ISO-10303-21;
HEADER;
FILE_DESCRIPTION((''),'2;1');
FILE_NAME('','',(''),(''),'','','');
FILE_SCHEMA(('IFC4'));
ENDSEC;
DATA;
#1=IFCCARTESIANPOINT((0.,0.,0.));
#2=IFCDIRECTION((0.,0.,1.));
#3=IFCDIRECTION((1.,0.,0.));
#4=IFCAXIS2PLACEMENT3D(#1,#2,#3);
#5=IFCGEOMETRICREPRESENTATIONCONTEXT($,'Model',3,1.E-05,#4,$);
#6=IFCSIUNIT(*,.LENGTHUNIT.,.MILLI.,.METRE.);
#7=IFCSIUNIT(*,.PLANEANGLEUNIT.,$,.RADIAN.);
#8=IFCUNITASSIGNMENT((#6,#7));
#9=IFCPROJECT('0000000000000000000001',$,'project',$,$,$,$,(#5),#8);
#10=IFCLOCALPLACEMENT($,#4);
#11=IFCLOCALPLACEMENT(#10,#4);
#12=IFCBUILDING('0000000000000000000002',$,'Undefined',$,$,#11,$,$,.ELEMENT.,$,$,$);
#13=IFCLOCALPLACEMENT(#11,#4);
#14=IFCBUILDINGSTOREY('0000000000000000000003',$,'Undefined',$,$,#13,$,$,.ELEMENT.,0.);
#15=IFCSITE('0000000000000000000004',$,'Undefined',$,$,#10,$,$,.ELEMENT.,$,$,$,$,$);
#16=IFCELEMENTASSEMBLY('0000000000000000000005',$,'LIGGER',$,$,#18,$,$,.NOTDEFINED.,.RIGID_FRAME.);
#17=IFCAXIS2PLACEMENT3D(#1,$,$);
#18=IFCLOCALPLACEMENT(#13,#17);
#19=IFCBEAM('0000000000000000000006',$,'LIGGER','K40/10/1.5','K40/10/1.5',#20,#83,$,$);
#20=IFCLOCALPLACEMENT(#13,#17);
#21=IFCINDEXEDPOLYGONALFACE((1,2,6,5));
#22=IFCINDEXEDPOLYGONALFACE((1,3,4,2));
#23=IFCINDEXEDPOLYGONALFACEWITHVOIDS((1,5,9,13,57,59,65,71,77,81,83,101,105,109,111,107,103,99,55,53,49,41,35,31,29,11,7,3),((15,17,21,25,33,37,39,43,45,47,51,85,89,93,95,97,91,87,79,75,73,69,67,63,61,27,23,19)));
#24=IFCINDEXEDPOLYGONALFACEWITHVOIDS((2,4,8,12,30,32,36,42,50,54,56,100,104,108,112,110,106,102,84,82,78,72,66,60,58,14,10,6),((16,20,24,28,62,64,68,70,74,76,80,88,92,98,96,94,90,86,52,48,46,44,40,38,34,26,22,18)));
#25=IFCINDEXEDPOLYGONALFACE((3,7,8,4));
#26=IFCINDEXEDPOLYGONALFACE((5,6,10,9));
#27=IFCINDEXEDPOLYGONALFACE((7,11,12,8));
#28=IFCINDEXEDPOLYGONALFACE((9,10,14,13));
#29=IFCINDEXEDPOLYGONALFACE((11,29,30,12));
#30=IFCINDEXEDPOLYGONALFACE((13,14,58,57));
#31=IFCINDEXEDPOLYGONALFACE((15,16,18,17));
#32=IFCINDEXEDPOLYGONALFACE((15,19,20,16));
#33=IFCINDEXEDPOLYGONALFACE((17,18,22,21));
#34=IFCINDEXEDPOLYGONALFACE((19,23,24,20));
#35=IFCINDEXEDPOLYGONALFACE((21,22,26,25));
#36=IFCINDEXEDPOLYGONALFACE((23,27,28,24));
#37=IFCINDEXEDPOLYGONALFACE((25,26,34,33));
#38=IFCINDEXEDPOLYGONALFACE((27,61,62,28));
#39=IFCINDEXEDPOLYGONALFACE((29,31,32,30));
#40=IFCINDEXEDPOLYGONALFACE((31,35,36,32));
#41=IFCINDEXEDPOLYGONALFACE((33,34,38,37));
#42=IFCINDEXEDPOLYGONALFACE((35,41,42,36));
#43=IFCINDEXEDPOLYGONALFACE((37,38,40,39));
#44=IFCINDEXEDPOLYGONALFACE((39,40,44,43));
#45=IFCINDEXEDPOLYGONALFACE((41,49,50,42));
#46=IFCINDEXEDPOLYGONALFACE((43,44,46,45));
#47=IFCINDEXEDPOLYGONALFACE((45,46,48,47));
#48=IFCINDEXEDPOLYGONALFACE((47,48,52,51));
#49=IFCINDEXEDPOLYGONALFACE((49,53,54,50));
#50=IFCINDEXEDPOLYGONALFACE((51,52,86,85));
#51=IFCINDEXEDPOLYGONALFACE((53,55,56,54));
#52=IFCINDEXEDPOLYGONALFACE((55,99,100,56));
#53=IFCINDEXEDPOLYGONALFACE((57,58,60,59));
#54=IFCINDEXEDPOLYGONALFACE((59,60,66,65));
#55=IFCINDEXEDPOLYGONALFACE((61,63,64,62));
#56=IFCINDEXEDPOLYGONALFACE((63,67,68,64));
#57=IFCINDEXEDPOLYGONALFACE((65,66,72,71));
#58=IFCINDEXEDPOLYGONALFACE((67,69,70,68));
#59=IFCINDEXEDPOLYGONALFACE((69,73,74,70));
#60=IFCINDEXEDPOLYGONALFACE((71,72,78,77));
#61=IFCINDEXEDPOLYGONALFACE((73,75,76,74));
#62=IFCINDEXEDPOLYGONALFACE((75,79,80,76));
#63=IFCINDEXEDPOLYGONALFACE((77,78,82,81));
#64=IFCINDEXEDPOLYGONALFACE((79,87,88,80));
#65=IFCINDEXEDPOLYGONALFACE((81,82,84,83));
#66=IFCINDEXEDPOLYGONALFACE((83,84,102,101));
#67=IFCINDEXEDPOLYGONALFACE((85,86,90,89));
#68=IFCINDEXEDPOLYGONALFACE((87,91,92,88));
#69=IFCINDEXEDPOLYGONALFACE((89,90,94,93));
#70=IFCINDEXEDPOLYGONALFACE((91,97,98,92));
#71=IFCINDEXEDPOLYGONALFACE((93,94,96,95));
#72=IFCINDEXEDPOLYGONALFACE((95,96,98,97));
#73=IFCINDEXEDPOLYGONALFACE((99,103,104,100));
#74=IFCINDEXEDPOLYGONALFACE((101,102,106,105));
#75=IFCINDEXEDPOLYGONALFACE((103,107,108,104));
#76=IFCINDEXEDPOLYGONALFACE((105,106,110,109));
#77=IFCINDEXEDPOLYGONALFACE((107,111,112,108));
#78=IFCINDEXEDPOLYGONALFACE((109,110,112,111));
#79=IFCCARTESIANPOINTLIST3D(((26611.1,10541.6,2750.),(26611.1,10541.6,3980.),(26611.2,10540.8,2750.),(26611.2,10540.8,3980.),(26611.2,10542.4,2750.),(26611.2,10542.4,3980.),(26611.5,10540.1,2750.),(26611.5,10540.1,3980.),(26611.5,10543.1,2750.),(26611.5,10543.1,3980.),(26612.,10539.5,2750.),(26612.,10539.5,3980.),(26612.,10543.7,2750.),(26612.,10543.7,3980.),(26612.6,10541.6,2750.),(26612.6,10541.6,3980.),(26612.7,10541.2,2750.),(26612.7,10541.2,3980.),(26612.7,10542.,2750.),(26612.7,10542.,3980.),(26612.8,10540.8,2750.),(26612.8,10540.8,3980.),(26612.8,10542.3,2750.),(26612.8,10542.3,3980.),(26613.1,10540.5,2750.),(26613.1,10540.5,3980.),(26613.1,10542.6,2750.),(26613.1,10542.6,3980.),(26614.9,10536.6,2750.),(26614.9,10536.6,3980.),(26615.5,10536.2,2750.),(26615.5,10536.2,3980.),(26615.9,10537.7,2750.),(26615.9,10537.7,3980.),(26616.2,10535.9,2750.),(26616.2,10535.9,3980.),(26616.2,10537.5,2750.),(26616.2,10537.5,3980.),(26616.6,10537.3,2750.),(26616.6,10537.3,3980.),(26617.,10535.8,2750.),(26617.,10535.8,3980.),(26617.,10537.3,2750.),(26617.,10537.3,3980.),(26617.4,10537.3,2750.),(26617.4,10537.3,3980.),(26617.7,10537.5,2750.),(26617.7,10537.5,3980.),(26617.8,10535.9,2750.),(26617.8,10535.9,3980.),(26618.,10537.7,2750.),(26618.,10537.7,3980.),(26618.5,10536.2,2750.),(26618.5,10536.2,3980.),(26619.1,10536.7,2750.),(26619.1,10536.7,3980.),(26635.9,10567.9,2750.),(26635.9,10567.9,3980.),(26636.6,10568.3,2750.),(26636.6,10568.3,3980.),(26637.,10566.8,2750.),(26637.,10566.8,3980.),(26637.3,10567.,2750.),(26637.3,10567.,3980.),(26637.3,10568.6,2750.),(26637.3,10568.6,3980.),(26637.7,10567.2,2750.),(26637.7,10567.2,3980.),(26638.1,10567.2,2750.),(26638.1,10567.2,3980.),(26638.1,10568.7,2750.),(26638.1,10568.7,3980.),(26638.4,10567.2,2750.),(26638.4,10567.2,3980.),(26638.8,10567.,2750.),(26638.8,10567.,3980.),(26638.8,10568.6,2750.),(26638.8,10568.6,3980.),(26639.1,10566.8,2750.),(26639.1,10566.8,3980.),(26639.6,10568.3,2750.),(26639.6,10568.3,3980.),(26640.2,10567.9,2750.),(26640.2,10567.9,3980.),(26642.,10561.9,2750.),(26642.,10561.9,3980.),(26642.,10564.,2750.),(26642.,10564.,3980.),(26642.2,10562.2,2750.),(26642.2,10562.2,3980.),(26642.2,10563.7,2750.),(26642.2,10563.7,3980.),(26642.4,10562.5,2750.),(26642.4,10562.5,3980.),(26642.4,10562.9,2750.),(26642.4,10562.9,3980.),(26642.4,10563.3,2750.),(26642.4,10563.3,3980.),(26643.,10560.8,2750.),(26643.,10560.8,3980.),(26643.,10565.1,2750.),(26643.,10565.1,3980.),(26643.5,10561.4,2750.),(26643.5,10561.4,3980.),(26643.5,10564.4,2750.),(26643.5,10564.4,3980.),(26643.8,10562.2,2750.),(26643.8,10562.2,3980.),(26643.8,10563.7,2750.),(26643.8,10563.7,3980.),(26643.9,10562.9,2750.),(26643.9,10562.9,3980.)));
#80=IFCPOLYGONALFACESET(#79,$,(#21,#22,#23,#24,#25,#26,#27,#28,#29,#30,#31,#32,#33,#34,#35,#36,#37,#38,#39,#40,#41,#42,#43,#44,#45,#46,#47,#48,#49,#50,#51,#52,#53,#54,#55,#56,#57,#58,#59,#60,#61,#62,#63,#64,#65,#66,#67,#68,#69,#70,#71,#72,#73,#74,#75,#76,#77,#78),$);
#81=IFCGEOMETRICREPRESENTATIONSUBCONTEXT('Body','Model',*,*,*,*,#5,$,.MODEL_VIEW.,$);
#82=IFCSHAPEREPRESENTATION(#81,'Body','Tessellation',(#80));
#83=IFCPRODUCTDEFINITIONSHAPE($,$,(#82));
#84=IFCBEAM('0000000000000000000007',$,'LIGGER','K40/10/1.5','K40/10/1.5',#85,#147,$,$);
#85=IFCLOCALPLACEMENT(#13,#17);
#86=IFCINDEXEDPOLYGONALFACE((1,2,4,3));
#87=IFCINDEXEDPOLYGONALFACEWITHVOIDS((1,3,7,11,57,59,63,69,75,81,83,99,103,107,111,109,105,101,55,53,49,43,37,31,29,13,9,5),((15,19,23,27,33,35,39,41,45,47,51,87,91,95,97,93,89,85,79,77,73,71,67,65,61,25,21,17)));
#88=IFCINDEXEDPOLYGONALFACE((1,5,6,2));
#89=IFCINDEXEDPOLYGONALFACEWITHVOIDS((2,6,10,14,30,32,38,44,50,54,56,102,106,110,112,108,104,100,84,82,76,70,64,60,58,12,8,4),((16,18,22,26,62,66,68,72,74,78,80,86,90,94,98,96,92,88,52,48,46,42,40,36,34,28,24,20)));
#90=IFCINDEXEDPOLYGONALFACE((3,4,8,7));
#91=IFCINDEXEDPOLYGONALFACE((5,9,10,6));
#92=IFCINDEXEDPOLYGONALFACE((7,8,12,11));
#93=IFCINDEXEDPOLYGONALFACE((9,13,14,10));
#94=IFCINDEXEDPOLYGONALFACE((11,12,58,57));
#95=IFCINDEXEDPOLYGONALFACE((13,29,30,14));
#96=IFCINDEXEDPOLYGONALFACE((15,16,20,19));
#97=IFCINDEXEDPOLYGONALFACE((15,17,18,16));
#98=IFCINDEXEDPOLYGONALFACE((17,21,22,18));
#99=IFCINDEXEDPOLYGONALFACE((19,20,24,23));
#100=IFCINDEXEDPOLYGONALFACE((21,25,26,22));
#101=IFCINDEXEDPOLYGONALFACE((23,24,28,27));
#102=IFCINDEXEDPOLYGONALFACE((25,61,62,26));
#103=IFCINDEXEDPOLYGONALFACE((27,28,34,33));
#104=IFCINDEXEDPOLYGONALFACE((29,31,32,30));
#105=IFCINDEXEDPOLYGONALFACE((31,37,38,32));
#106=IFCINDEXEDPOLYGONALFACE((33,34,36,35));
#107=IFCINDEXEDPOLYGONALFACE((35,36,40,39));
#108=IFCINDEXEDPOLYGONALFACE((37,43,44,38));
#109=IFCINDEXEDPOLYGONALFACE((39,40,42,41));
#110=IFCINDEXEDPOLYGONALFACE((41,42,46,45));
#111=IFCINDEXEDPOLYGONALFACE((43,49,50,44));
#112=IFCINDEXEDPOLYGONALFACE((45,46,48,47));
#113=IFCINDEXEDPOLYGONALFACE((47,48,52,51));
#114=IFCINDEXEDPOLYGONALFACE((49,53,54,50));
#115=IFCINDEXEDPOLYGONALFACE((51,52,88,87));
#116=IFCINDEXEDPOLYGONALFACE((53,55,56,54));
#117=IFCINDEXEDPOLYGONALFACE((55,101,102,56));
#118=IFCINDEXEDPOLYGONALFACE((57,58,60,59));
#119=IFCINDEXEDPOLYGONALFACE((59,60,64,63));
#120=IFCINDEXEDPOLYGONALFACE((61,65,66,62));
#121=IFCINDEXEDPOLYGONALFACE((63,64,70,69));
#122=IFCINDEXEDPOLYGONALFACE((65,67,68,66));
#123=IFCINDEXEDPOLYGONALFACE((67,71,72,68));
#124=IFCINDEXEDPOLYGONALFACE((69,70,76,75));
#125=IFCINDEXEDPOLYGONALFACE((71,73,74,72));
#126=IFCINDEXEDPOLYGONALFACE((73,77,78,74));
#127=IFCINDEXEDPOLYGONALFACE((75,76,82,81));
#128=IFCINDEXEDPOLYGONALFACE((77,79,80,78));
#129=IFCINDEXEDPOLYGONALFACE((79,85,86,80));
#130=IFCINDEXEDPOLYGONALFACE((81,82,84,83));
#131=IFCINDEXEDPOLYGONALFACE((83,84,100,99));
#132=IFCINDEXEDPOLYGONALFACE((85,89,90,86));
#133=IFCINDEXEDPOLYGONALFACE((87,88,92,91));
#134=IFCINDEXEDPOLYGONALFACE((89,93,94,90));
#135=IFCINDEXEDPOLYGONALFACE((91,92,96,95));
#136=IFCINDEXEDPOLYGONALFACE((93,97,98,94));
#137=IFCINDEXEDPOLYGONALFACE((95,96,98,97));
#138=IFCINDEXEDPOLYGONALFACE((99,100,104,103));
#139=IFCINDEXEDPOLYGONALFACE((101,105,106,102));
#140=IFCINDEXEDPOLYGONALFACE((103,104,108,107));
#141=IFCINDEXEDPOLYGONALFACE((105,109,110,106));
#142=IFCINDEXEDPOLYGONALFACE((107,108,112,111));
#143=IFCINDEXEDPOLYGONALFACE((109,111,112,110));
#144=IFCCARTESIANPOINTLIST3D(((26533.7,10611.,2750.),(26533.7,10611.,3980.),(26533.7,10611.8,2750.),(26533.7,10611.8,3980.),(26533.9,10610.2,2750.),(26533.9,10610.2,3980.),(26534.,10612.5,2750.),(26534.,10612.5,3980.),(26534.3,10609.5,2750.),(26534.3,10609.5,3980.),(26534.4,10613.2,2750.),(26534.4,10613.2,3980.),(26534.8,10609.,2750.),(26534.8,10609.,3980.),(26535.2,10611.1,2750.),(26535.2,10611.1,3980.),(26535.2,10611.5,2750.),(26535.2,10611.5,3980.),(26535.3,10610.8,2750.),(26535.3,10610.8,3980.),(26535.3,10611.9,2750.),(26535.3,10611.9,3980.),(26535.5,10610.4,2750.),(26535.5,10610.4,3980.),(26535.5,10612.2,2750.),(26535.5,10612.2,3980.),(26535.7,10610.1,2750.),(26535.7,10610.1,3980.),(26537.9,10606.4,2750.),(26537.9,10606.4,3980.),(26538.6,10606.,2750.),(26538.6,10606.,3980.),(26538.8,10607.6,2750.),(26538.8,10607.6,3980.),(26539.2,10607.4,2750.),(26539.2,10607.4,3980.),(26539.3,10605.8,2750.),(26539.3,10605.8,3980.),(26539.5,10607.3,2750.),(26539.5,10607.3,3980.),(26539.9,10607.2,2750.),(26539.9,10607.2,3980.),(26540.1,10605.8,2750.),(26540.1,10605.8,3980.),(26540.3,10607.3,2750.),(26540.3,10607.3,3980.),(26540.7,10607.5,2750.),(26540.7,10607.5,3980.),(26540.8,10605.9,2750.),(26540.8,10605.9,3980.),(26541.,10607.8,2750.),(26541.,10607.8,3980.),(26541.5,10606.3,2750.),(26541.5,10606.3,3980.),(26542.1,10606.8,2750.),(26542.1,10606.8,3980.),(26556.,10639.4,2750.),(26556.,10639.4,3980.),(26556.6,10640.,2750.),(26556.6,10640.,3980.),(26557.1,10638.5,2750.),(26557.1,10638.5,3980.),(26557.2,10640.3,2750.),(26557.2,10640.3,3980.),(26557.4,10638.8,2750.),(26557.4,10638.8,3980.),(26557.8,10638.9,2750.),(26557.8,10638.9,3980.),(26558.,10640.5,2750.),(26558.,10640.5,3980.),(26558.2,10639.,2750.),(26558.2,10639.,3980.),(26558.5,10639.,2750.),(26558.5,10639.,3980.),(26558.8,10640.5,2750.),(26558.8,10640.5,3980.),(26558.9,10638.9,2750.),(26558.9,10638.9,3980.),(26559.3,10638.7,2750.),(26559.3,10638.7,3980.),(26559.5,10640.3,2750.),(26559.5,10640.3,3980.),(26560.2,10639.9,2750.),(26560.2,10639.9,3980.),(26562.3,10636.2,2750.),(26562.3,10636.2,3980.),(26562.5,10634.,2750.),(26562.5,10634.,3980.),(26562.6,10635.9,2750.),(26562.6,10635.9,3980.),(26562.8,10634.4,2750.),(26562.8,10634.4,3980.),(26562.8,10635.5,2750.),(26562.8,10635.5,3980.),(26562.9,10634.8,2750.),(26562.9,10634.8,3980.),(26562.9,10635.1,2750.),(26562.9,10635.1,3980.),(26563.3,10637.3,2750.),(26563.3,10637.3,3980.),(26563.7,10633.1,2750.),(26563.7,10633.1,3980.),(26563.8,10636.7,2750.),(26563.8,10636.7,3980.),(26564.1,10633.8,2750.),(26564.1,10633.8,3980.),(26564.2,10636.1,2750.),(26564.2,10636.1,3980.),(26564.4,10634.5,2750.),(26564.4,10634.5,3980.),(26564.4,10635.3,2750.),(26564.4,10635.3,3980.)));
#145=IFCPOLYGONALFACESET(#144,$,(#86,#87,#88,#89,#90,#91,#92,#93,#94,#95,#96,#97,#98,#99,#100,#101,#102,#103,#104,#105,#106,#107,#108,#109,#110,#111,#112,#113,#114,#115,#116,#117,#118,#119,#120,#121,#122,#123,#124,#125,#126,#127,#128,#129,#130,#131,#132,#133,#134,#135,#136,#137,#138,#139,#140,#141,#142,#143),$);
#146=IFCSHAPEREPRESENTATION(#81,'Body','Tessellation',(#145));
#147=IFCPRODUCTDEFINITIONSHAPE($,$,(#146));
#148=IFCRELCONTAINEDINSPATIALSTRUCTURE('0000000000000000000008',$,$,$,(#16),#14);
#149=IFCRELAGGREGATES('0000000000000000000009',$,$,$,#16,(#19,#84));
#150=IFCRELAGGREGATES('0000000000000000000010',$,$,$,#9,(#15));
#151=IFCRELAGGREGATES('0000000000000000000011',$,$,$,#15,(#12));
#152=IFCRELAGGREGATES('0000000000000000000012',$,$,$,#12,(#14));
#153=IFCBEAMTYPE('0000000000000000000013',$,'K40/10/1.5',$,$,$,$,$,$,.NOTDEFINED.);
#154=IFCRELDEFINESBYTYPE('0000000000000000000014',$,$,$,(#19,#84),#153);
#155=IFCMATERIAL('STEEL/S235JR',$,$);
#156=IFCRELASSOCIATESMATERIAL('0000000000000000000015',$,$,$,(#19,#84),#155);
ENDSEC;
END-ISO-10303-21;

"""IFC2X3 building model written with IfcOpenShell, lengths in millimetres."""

from ifc_helpers import new_model, si_unit, frame, origin_with_axes, origin_2d_with_axis, place, context, subcontext, project, spatial, hollow_rectangle, extrude, material, type_object, element, aggregate, save


model = new_model("IFC2X3")

# Units and contexts
model_context = context("Model", 3, precision=1e-05, world=origin_with_axes())
body_context = subcontext(model_context, "Body", "Model", "MODEL_VIEW")
ifc_project = project(units=[si_unit("LENGTHUNIT", "METRE", prefix="MILLI"), si_unit("PLANEANGLEUNIT", "RADIAN")], contexts=[model_context])

# Site, building, storey
site_placement = place(None, origin_with_axes())
site = spatial("IfcSite", under=ifc_project, at=site_placement, Name="Undefined", CompositionType="ELEMENT")
building_placement = place(site_placement, origin_with_axes())
building = spatial("IfcBuilding", under=site, at=building_placement, Name="Undefined", CompositionType="ELEMENT")
storey_placement = place(building_placement, origin_with_axes())
storey = spatial("IfcBuildingStorey", under=building, at=storey_placement, Name="Undefined", CompositionType="ELEMENT", Elevation=0.0)

# Element assembly
ifc_material_1 = material(Name="STEEL/S235JR")
assembly_1_placement = place(storey_placement, origin_with_axes())
assembly_1 = element("IfcElementAssembly", 1, at=assembly_1_placement, inside=storey, Name="LIGGER", AssemblyPlace="NOTDEFINED", PredefinedType="RIGID_FRAME")
beam_type_1 = type_object("IfcBeamType", Name="K40/10/1.5", PredefinedType="NOTDEFINED")

# Beams
beam_1_placement = place(assembly_1_placement, frame((26627.5, 10552.3, 3980.0), z_axis=(0.703907, 0.710292, 0.0), x_axis=(0.0, 0.0, -1.0)))
beam_1 = element("IfcBeam", 2, at=beam_1_placement, type_object=beam_type_1, material=ifc_material_1, Name="LIGGER", Description="K40/10/1.5", ObjectType="K40/10/1.5", context=body_context, shape_type="SweptSolid", body=[
    extrude(hollow_rectangle(XDim=10.0, YDim=40.0, WallThickness=1.5, InnerFilletRadius=1.5, OuterFilletRadius=3.0, at=origin_2d_with_axis()), frame((1230.0, 0.0, 0.0), z_axis=(-1.0, 0.0, 0.0), x_axis=(0.0, -1.0, 0.0)), (0.0, 0.0, 1.0), 1230.0),
])
beam_2_placement = place(assembly_1_placement, frame((26549.0, 10623.1, 3980.0), z_axis=(0.635288, 0.772275, 0.0), x_axis=(0.0, 0.0, -1.0)))
beam_2 = element("IfcBeam", 3, at=beam_2_placement, type_object=beam_type_1, material=ifc_material_1, Name="LIGGER", Description="K40/10/1.5", ObjectType="K40/10/1.5", context=body_context, shape_type="SweptSolid", body=[
    extrude(hollow_rectangle(XDim=10.0, YDim=40.0, WallThickness=1.5, InnerFilletRadius=1.5, OuterFilletRadius=3.0, at=origin_2d_with_axis()), frame((1230.0, 0.0, 0.0), z_axis=(-1.0, 0.0, 0.0), x_axis=(0.0, -1.0, 0.0)), (0.0, 0.0, 1.0), 1230.0),
])

aggregate(assembly_1, [beam_1, beam_2])

save(model, "model.ifc")
